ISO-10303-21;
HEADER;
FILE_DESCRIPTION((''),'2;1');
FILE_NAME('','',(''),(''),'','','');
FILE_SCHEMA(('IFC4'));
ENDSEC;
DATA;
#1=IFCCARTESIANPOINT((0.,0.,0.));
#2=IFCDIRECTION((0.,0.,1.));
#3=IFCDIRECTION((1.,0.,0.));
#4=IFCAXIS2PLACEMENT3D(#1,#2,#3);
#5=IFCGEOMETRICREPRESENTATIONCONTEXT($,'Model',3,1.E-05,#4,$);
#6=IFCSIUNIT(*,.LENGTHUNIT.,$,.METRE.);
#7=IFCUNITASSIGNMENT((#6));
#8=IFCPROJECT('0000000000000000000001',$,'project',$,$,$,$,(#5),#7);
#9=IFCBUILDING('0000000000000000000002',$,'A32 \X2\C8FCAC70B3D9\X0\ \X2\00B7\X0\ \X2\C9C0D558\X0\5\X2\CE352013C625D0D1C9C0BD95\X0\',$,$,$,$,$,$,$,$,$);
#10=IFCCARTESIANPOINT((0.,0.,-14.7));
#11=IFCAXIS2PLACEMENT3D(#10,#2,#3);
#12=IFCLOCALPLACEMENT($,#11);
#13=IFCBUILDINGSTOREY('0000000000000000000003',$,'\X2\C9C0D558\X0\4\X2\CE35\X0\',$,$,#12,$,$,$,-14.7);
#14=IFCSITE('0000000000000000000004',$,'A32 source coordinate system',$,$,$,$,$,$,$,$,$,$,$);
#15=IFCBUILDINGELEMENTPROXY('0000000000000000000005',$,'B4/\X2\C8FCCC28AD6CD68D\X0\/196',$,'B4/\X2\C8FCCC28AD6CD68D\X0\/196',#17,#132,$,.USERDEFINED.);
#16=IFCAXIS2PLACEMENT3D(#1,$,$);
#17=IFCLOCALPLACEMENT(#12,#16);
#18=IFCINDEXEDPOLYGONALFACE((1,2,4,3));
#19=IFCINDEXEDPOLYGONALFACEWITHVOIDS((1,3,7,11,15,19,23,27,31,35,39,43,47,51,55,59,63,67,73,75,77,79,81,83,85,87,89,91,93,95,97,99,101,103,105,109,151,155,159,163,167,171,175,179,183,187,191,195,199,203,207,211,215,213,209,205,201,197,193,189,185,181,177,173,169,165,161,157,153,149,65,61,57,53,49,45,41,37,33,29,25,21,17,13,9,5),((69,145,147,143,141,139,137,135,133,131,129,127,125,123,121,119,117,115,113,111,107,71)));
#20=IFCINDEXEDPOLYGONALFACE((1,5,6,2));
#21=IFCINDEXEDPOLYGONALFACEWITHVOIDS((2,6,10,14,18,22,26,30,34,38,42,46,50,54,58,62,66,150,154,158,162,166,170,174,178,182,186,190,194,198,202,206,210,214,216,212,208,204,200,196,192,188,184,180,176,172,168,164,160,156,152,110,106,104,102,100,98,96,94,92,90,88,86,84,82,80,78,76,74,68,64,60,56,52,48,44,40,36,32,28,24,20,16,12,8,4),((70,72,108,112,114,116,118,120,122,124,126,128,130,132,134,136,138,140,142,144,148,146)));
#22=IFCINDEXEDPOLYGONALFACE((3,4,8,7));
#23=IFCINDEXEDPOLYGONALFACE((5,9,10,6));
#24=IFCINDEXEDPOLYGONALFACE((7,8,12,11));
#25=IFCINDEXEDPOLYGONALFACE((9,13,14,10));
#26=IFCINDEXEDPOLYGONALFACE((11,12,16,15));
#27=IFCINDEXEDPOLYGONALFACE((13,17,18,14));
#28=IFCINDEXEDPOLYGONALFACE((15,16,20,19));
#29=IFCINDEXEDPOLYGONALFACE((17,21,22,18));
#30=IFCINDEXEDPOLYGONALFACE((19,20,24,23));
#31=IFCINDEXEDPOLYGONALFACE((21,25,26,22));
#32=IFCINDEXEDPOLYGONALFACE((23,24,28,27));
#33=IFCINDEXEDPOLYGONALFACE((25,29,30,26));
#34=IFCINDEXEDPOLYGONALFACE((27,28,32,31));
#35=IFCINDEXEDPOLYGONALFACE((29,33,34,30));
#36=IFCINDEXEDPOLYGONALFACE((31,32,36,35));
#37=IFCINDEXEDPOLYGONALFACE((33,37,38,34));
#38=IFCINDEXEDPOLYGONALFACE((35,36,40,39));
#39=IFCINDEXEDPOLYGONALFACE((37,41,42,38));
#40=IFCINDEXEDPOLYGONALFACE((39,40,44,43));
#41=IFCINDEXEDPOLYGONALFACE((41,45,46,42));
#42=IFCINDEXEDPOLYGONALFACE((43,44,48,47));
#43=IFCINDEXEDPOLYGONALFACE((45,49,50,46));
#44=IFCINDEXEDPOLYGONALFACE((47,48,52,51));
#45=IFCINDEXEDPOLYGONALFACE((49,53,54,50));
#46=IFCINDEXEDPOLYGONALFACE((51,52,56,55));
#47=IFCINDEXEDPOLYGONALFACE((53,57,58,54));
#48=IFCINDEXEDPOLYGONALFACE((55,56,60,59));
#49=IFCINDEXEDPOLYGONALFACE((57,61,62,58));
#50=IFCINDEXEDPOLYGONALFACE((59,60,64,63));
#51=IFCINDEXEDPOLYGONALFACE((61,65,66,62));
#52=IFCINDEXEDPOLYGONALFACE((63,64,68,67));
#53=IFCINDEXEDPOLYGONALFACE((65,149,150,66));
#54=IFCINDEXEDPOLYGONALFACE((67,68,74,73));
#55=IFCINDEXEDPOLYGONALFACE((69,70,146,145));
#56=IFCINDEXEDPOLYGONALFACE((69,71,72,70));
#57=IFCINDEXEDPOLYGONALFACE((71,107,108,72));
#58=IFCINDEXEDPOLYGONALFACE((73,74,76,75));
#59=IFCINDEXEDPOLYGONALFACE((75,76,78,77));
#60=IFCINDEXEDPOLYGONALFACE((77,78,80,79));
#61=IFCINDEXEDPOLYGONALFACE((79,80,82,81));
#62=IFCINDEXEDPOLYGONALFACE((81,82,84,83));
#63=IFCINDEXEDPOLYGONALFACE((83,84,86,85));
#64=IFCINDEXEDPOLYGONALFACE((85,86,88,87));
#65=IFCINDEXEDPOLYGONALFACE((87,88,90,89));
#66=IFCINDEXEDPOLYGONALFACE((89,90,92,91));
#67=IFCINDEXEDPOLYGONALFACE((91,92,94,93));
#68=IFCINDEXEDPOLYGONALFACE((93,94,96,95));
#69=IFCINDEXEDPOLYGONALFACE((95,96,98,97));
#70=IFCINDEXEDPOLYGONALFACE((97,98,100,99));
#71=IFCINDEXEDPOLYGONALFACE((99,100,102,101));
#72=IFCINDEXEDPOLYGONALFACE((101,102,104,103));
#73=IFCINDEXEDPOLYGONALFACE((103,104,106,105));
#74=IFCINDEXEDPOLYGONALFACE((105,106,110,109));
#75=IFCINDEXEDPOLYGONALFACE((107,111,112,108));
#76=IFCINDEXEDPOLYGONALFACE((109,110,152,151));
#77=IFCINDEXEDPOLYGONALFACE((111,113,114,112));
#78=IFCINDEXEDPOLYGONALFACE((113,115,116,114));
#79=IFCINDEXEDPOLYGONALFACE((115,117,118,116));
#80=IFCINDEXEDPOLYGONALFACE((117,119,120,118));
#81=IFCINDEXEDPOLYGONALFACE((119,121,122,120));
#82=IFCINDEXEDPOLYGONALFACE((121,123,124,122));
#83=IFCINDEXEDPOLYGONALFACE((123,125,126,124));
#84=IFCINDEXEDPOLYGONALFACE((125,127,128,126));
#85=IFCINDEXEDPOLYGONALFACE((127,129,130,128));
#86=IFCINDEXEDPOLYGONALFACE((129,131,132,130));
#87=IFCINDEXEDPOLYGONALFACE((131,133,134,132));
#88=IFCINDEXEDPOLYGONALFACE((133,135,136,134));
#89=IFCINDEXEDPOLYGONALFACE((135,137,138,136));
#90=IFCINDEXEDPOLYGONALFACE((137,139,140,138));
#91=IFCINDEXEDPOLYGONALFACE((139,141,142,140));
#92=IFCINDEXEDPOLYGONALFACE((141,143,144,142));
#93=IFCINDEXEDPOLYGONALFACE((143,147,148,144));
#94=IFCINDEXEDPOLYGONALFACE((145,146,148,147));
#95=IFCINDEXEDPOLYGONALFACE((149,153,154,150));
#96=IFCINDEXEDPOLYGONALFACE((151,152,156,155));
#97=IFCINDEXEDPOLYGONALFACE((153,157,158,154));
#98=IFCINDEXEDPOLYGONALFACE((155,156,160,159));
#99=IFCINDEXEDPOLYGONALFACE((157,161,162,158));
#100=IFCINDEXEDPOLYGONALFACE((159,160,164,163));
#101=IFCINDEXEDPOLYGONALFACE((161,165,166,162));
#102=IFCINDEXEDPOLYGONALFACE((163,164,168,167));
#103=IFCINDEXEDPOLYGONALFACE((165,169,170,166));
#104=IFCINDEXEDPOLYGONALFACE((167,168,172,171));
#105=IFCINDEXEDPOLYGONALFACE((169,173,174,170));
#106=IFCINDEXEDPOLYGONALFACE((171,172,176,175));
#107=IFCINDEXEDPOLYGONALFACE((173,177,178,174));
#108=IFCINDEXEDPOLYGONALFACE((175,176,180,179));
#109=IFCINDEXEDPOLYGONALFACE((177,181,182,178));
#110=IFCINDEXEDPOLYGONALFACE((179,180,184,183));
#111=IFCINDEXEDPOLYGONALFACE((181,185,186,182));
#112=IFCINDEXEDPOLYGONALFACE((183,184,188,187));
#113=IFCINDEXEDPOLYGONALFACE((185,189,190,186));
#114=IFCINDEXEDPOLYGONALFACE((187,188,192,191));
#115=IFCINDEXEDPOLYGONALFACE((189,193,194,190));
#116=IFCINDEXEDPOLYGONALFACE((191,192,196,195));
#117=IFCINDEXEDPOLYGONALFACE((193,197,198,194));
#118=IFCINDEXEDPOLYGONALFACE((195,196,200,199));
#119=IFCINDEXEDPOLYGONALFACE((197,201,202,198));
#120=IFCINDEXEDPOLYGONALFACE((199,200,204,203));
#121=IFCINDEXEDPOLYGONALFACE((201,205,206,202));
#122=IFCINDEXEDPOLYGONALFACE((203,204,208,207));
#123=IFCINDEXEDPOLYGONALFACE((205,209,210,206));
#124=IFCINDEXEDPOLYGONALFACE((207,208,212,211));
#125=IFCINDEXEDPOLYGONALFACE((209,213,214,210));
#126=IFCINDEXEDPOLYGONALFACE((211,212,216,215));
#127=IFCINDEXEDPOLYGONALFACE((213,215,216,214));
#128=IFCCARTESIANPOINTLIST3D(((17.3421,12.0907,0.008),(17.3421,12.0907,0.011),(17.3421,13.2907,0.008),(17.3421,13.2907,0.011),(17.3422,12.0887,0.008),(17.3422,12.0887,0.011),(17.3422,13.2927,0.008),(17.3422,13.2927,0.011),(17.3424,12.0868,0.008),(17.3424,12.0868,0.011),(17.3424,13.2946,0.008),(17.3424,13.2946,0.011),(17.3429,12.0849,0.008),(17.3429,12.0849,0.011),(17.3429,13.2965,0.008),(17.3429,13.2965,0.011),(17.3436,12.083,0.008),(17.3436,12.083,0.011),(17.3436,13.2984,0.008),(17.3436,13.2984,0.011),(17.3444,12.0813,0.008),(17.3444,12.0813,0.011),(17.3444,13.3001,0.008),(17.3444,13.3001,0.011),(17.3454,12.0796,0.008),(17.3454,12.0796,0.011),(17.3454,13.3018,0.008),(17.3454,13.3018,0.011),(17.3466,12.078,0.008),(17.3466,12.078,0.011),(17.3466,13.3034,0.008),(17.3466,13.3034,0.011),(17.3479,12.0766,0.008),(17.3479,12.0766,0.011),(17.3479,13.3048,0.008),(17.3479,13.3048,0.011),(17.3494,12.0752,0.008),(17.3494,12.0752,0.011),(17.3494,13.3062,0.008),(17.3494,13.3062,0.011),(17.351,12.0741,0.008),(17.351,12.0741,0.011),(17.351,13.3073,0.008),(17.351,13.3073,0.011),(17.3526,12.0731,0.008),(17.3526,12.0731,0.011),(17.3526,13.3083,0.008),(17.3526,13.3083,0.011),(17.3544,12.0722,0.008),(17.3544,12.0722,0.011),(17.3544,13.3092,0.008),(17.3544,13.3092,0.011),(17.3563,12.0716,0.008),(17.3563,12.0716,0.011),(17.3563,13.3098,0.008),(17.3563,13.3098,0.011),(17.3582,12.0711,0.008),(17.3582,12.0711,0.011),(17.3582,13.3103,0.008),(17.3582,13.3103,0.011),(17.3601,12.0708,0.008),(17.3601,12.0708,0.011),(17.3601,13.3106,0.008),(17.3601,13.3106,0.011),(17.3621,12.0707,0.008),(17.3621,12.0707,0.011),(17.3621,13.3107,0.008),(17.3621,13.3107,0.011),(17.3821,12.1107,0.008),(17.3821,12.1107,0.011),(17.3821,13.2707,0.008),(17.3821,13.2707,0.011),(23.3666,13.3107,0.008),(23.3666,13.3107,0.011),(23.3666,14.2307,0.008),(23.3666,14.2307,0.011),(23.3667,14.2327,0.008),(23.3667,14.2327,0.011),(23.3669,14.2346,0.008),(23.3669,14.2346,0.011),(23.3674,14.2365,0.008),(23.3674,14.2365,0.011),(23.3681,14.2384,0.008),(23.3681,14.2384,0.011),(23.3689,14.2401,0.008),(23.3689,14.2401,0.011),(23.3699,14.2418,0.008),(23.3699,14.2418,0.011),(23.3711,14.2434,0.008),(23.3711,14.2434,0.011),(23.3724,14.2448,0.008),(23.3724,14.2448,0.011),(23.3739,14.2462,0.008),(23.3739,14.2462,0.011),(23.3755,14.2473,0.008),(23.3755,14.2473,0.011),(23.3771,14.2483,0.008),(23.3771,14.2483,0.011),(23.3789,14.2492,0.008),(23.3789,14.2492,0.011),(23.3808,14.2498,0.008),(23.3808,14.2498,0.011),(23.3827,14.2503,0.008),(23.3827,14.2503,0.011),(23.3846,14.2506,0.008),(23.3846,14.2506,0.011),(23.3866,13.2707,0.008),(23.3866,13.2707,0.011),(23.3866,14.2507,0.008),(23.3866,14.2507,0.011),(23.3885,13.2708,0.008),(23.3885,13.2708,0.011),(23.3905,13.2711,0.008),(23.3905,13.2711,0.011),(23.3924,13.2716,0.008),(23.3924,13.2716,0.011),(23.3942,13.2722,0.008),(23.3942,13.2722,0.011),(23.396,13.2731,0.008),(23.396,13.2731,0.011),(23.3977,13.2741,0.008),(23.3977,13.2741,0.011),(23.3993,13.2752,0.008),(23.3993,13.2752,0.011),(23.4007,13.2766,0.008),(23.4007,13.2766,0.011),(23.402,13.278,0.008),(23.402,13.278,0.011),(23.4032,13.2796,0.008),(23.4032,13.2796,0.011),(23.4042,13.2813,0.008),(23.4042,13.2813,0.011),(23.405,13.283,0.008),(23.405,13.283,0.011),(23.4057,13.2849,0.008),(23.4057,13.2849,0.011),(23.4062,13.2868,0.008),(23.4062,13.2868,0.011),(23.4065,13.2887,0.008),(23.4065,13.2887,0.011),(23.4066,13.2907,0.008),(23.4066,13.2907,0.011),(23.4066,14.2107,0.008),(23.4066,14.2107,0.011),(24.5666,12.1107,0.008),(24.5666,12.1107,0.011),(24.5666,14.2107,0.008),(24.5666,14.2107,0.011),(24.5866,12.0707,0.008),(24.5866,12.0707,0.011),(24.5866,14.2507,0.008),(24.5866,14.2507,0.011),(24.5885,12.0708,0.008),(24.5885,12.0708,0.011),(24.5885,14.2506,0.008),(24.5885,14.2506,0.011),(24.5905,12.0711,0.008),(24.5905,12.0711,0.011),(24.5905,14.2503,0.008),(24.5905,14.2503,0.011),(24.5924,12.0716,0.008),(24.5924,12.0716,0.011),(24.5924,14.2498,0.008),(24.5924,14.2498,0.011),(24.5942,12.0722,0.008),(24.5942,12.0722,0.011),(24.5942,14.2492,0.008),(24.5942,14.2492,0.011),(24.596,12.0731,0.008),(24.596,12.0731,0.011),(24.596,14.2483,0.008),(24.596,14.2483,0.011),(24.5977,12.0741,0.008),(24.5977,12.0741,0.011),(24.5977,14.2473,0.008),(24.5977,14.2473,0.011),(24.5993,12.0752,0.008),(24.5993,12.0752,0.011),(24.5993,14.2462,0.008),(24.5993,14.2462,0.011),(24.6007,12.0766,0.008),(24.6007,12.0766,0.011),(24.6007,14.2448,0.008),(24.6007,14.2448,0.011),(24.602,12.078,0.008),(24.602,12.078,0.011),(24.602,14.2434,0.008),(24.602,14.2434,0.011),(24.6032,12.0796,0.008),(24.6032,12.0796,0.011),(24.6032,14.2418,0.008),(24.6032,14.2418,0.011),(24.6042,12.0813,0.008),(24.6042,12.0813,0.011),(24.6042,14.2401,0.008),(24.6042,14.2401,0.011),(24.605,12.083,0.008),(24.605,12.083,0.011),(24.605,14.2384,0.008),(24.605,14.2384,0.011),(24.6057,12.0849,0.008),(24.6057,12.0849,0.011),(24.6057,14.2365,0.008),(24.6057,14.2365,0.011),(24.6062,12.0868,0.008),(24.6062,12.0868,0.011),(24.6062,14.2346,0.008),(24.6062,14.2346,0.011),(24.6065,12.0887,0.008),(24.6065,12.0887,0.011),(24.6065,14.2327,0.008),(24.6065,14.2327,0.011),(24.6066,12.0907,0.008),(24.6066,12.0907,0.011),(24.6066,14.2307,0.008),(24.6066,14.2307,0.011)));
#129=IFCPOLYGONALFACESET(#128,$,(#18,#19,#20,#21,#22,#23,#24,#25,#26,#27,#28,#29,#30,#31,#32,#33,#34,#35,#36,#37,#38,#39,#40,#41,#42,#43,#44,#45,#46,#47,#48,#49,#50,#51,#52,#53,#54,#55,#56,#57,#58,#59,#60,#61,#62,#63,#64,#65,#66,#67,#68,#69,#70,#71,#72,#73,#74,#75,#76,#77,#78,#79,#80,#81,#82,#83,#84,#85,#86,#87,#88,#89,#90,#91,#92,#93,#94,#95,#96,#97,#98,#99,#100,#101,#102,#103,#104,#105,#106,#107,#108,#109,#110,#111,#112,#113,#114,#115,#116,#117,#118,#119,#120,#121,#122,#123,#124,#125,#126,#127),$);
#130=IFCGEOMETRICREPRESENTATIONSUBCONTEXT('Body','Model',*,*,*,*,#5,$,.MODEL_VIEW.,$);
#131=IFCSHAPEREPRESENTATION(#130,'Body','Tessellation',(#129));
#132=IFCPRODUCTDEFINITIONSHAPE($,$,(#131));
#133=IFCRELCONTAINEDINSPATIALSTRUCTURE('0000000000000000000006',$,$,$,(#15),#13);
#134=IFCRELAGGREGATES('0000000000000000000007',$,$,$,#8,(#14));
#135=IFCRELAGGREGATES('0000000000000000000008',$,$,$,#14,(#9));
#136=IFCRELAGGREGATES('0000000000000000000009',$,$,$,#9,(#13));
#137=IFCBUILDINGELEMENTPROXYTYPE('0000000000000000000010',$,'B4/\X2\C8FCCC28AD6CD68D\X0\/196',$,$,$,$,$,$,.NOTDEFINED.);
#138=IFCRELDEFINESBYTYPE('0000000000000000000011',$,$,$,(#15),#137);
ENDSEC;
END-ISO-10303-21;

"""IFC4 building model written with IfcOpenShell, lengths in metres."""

from ifc_helpers import new_model, si_unit, frame, origin, origin_with_axes, place, context, subcontext, project, spatial, polyline, outline, extrude, source, transform, mapped, type_object, type_shapes, element, save


model = new_model("IFC4")

# Units and contexts
model_context = context("Model", 3, precision=1e-05, world=origin_with_axes())
body_context = subcontext(model_context, "Body", "Model", "MODEL_VIEW")
ifc_project = project(units=[si_unit("LENGTHUNIT", "METRE")], contexts=[model_context])

# Site, building, storey
site = spatial("IfcSite", under=ifc_project, Name="A32 source coordinate system")
building = spatial("IfcBuilding", under=site, Name="A32 주거동 · 지하5층–옥탑지붕")
storey_placement = place(None, frame((0.0, 0.0, -14.7), z_axis=(0.0, 0.0, 1.0), x_axis=(1.0, 0.0, 0.0)))
storey = spatial("IfcBuildingStorey", under=building, at=storey_placement, Name="지하4층", Elevation=-14.7)

# Building element proxy
building_element_proxy_type_1 = type_object("IfcBuildingElementProxyType", Name="B4/주차구획/196", PredefinedType="NOTDEFINED")
shared_shape_1 = source(origin(), body_context, "Body", "SweptSolid", [
    extrude(outline(polyline([(24.5866, 14.2507), (24.5885, 14.2506), (24.5905, 14.2503), (24.5924, 14.2498), (24.5942, 14.2492), (24.596, 14.2483), (24.5977, 14.2473), (24.5993, 14.2462), (24.6007, 14.2448), (24.602, 14.2434), (24.6032, 14.2418), (24.6042, 14.2401), (24.605, 14.2384), (24.6057, 14.2365), (24.6062, 14.2346), (24.6065, 14.2327), (24.6066, 14.2307), (24.6066, 12.0907), (24.6065, 12.0887), (24.6062, 12.0868), (24.6057, 12.0849), (24.605, 12.083), (24.6042, 12.0813), (24.6032, 12.0796), (24.602, 12.078), (24.6007, 12.0766), (24.5993, 12.0752), (24.5977, 12.0741), (24.596, 12.0731), (24.5942, 12.0722), (24.5924, 12.0716), (24.5905, 12.0711), (24.5885, 12.0708), (24.5866, 12.0707), (17.3621, 12.0707), (17.3601, 12.0708), (17.3582, 12.0711), (17.3563, 12.0716), (17.3544, 12.0722), (17.3526, 12.0731), (17.351, 12.0741), (17.3494, 12.0752), (17.3479, 12.0766), (17.3466, 12.078), (17.3454, 12.0796), (17.3444, 12.0813), (17.3436, 12.083), (17.3429, 12.0849), (17.3424, 12.0868), (17.3422, 12.0887), (17.3421, 12.0907), (17.3421, 13.2907), (17.3422, 13.2927), (17.3424, 13.2946), (17.3429, 13.2965), (17.3436, 13.2984), (17.3444, 13.3001), (17.3454, 13.3018), (17.3466, 13.3034), (17.3479, 13.3048), (17.3494, 13.3062), (17.351, 13.3073), (17.3526, 13.3083), (17.3544, 13.3092), (17.3563, 13.3098), (17.3582, 13.3103), (17.3601, 13.3106), (17.3621, 13.3107), (23.3666, 13.3107), (23.3666, 14.2307), (23.3667, 14.2327), (23.3669, 14.2346), (23.3674, 14.2365), (23.3681, 14.2384), (23.3689, 14.2401), (23.3699, 14.2418), (23.3711, 14.2434), (23.3724, 14.2448), (23.3739, 14.2462), (23.3755, 14.2473), (23.3771, 14.2483), (23.3789, 14.2492), (23.3808, 14.2498), (23.3827, 14.2503), (23.3846, 14.2506), (23.3866, 14.2507), (24.5866, 14.2507)]), holes=[polyline([(24.5666, 14.2107), (23.4066, 14.2107), (23.4066, 13.2907), (23.4065, 13.2887), (23.4062, 13.2868), (23.4057, 13.2849), (23.405, 13.283), (23.4042, 13.2813), (23.4032, 13.2796), (23.402, 13.278), (23.4007, 13.2766), (23.3993, 13.2752), (23.3977, 13.2741), (23.396, 13.2731), (23.3942, 13.2722), (23.3924, 13.2716), (23.3905, 13.2711), (23.3885, 13.2708), (23.3866, 13.2707), (17.3821, 13.2707), (17.3821, 12.1107), (24.5666, 12.1107), (24.5666, 14.2107)])]), frame((0.0, 0.0, 0.008)), (0.0, 0.0, 1.0), 0.003),
])
type_shapes(building_element_proxy_type_1, [shared_shape_1])
proxy_1_placement = place(storey_placement, origin_with_axes())
element("IfcBuildingElementProxy", 1, at=proxy_1_placement, inside=storey, type_object=building_element_proxy_type_1, Name="B4/주차구획/196", ObjectType="B4/주차구획/196", PredefinedType="USERDEFINED", context=body_context, shape_type="MappedRepresentation", body=[
    mapped(shared_shape_1, transform((0.0, 0.0, 0.0), scale=1.0)),
])

save(model, "model.ifc")
